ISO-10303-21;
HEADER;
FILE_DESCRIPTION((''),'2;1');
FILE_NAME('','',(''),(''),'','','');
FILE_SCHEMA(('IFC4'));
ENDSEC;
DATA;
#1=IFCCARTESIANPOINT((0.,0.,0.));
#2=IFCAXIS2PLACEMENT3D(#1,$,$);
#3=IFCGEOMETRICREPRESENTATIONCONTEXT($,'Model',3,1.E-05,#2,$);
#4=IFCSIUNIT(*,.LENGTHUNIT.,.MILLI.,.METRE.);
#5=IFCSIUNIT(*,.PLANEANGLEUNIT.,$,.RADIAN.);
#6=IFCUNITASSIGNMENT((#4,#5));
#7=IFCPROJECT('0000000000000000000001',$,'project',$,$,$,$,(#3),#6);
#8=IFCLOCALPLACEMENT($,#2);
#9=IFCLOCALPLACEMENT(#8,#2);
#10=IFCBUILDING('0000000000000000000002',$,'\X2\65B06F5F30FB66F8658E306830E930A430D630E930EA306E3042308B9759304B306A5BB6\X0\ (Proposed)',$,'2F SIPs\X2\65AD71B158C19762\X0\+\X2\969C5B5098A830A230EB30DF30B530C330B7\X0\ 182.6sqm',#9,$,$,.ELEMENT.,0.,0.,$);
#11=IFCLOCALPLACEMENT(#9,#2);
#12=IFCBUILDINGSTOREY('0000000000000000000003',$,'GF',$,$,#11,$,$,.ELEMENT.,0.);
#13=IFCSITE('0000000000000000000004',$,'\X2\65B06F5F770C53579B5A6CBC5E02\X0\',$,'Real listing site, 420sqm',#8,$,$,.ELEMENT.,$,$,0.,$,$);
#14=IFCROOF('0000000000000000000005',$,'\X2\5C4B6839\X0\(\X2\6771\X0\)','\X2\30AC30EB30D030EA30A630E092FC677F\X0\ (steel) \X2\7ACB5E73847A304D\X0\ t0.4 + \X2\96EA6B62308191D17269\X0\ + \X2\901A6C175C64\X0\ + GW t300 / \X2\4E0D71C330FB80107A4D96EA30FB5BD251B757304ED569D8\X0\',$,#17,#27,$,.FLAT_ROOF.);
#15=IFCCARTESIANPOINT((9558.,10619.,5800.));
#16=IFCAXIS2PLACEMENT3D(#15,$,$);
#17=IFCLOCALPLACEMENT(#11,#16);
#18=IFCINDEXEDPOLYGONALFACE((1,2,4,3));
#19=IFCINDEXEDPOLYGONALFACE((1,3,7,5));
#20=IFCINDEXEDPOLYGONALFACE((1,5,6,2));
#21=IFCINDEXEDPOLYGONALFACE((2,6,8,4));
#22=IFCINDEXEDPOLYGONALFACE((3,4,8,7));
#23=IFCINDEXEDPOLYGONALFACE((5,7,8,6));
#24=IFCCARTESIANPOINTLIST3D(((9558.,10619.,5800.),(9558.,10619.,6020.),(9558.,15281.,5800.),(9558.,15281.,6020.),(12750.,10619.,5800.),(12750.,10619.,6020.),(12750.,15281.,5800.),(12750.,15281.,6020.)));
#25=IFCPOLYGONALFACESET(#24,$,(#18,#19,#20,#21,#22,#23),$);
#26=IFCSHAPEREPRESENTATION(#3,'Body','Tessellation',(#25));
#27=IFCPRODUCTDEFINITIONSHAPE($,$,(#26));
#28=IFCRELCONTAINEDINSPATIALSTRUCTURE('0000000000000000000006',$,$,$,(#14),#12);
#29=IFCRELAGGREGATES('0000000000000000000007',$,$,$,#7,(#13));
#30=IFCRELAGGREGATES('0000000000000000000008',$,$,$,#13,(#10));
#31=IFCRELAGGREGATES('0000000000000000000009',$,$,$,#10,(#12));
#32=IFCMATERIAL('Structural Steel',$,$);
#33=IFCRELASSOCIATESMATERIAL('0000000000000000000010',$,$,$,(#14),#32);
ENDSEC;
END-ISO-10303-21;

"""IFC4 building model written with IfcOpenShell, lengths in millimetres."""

from ifc_helpers import new_model, si_unit, frame, frame_2d, origin, place, context, project, spatial, rectangle, extrude, material, element, save


model = new_model("IFC4")

# Units and contexts
model_context = context("Model", 3, precision=1e-05, world=origin())
ifc_project = project(units=[si_unit("LENGTHUNIT", "METRE", prefix="MILLI"), si_unit("PLANEANGLEUNIT", "RADIAN")], contexts=[model_context])

# Site, building, storey
site_placement = place(None, origin())
site = spatial("IfcSite", under=ifc_project, at=site_placement, Name="新潟県南魚沼市", ObjectType="Real listing site, 420sqm", CompositionType="ELEMENT", RefElevation=0.0)
building_placement = place(site_placement, origin())
building = spatial("IfcBuilding", under=site, at=building_placement, Name="新潟・書斎とライブラリのある静かな家 (Proposed)", ObjectType="2F SIPs断熱壁面+障子風アルミサッシ 182.6sqm", CompositionType="ELEMENT", ElevationOfRefHeight=0.0, ElevationOfTerrain=0.0)
storey_placement = place(building_placement, origin())
storey = spatial("IfcBuildingStorey", under=building, at=storey_placement, Name="GF", CompositionType="ELEMENT", Elevation=0.0)

# Roof
ifc_material_1 = material(Name="Structural Steel")
for number, where, name in (
    (1, (9558.0, 10619.0, 5800.0), "屋根(東)"),
):
    element("IfcRoof", number, at=place(storey_placement, frame(where)), inside=storey, material=ifc_material_1, Name=name, Description="ガルバリウム鋼板 (steel) 立平葺き t0.4 + 雪止め金物 + 通気層 + GW t300 / 不燃・耐積雪・寒冷地仕様", PredefinedType="FLAT_ROOF", context=model_context, shape_type="SweptSolid", body=[
        extrude(rectangle(XDim=3192.0, YDim=4662.0, at=frame_2d((1596.0, 2331.0))), frame((9558.0, 10619.0, 5800.0)), (0.0, 0.0, 1.0), 220.0),
    ])

save(model, "model.ifc")
